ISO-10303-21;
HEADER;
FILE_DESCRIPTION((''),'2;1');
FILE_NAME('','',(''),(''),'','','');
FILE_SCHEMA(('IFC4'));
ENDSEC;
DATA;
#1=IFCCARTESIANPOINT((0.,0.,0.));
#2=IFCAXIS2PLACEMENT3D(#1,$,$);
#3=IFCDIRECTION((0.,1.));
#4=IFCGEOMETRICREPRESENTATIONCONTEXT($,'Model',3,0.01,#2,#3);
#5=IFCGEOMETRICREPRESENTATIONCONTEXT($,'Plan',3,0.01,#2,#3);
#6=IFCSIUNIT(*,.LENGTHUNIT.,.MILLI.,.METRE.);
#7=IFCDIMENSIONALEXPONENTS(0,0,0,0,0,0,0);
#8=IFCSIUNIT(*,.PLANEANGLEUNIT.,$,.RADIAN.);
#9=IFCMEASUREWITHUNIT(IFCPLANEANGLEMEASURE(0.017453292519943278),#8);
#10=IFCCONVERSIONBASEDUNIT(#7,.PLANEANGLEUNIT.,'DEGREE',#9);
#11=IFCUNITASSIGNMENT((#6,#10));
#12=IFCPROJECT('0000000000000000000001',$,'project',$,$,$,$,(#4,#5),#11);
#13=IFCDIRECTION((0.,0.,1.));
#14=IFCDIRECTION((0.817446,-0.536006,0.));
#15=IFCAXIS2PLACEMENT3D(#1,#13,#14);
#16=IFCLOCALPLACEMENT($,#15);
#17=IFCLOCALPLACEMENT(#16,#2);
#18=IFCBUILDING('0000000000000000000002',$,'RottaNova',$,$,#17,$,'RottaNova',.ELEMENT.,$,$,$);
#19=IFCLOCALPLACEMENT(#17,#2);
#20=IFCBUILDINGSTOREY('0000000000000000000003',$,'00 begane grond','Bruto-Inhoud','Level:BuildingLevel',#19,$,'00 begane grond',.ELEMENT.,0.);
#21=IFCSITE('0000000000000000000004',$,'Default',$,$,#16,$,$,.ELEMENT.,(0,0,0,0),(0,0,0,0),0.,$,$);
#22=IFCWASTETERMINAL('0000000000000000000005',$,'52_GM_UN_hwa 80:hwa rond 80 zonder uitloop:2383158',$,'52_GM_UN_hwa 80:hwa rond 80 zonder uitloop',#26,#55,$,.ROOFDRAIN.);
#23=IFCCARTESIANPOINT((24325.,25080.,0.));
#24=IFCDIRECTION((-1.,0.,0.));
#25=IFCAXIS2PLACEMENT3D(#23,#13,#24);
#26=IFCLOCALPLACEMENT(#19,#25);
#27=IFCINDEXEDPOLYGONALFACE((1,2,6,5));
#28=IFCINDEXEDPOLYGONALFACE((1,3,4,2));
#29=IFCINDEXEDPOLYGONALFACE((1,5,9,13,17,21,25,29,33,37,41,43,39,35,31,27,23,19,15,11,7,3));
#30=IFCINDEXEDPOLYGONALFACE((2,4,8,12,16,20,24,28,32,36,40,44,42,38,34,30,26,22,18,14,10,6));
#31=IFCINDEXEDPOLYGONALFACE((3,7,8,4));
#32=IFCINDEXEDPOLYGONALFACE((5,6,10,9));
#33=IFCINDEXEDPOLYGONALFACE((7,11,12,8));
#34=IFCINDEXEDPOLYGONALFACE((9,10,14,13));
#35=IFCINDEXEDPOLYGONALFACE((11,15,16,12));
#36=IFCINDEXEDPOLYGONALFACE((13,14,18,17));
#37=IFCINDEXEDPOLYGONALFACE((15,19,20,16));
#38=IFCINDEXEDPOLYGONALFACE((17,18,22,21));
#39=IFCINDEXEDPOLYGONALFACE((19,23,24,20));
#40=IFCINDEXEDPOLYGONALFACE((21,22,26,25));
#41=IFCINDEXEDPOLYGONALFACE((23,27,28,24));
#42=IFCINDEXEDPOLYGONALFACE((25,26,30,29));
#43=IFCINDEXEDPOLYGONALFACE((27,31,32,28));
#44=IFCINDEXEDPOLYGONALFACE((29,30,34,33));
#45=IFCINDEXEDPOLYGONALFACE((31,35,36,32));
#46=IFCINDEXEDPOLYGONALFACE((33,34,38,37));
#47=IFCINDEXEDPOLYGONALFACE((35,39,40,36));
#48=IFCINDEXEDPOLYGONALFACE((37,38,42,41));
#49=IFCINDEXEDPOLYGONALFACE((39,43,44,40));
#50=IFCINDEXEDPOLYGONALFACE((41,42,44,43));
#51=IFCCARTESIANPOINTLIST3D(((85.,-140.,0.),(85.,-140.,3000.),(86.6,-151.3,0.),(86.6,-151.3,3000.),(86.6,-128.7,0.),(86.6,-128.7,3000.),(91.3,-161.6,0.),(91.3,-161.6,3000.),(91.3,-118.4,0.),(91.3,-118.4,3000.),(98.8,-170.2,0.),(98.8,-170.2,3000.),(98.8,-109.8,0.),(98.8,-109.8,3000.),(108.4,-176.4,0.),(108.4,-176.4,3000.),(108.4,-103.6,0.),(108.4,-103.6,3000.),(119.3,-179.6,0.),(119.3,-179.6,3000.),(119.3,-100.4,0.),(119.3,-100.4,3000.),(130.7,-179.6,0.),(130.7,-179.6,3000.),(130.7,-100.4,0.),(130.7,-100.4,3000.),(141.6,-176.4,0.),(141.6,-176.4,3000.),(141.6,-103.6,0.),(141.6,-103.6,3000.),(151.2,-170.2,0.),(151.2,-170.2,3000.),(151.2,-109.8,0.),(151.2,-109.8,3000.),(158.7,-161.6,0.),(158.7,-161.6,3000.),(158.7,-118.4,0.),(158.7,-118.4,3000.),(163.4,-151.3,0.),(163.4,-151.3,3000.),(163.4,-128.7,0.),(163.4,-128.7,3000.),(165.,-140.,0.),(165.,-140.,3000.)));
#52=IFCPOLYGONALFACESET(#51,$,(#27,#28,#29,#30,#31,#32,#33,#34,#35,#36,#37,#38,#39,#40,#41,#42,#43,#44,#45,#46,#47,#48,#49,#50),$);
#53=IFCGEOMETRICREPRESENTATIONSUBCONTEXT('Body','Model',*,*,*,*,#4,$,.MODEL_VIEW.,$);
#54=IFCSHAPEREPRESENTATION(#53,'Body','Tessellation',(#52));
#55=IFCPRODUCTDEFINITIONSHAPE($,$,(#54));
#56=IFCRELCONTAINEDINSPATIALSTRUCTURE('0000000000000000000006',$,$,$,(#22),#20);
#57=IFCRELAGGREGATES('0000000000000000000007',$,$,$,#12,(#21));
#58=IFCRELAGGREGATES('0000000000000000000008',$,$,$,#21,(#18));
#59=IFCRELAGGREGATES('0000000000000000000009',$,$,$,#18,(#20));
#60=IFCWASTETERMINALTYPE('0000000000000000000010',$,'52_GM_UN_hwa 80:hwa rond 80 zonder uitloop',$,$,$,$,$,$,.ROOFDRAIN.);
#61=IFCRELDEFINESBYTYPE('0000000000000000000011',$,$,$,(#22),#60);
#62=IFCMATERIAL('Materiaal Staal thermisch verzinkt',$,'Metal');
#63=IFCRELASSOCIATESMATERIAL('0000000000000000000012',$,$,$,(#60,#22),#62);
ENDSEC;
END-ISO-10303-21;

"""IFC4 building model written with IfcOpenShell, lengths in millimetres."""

from ifc_helpers import new_model, entity, si_unit, converted_unit, direction, frame, origin, place, context, subcontext, project, spatial, arc, indexed_curve, outline, extrude, source, transform, mapped, material, type_object, type_shapes, element, save


model = new_model("IFC4")

# Units and contexts
model_context = context("Model", 3, precision=0.01, world=origin(), true_north=direction((0.0, 1.0)))
plan_context = context("Plan", 3, precision=0.01, world=origin(), true_north=direction((0.0, 1.0)))
body_context = subcontext(model_context, "Body", "Model", "MODEL_VIEW")
ifc_project = project(units=[si_unit("LENGTHUNIT", "METRE", prefix="MILLI"), converted_unit("PLANEANGLEUNIT", "DEGREE", entity("IfcPlaneAngleMeasure", 0.017453292519943278), si_unit("PLANEANGLEUNIT", "RADIAN"), dimensions=[0, 0, 0, 0, 0, 0, 0])], contexts=[model_context, plan_context])

# Site, building, storey
site_placement = place(None, frame((0.0, 0.0, 0.0), z_axis=(0.0, 0.0, 1.0), x_axis=(0.817446, -0.536006, 0.0)))
site = spatial("IfcSite", under=ifc_project, at=site_placement, Name="Default", CompositionType="ELEMENT", RefLatitude=(0, 0, 0, 0), RefLongitude=(0, 0, 0, 0), RefElevation=0.0)
building_placement = place(site_placement, origin())
building = spatial("IfcBuilding", under=site, at=building_placement, Name="RottaNova", LongName="RottaNova", CompositionType="ELEMENT")
storey_placement = place(building_placement, origin())
storey = spatial("IfcBuildingStorey", under=building, at=storey_placement, Name="00 begane grond", Description="Bruto-Inhoud", ObjectType="Level:BuildingLevel", LongName="00 begane grond", CompositionType="ELEMENT", Elevation=0.0)

# Waste terminal
ifc_material_1 = material(Name="Materiaal Staal thermisch verzinkt", Category="Metal")
waste_terminal_type = type_object("IfcWasteTerminalType", Name="52_GM_UN_hwa 80:hwa rond 80 zonder uitloop", PredefinedType="ROOFDRAIN", material=ifc_material_1)
shared_shape_1 = source(origin(), body_context, "Body", "SweptSolid", [
    extrude(outline(indexed_curve([(-40.0, 0.0), (0.0, -40.0), (40.0, 0.0), (0.0, 40.0)], segments=[arc(1, 2, 3), arc(3, 4, 1)], self_intersect=False)), frame((125.0, -140.0, 0.0)), (0.0, 0.0, 1.0), 3000.0),
])
type_shapes(waste_terminal_type, [shared_shape_1])
waste_terminal_placement = place(storey_placement, frame((24325.0, 25080.0, 0.0), z_axis=(0.0, 0.0, 1.0), x_axis=(-1.0, 0.0, 0.0)))
element("IfcWasteTerminal", 1, at=waste_terminal_placement, inside=storey, type_object=waste_terminal_type, material=ifc_material_1, Name="52_GM_UN_hwa 80:hwa rond 80 zonder uitloop:2383158", ObjectType="52_GM_UN_hwa 80:hwa rond 80 zonder uitloop", PredefinedType="ROOFDRAIN", context=body_context, shape_type="MappedRepresentation", body=[
    mapped(shared_shape_1, transform((0.0, 0.0, 0.0), scale=1.0)),
])

save(model, "model.ifc")
